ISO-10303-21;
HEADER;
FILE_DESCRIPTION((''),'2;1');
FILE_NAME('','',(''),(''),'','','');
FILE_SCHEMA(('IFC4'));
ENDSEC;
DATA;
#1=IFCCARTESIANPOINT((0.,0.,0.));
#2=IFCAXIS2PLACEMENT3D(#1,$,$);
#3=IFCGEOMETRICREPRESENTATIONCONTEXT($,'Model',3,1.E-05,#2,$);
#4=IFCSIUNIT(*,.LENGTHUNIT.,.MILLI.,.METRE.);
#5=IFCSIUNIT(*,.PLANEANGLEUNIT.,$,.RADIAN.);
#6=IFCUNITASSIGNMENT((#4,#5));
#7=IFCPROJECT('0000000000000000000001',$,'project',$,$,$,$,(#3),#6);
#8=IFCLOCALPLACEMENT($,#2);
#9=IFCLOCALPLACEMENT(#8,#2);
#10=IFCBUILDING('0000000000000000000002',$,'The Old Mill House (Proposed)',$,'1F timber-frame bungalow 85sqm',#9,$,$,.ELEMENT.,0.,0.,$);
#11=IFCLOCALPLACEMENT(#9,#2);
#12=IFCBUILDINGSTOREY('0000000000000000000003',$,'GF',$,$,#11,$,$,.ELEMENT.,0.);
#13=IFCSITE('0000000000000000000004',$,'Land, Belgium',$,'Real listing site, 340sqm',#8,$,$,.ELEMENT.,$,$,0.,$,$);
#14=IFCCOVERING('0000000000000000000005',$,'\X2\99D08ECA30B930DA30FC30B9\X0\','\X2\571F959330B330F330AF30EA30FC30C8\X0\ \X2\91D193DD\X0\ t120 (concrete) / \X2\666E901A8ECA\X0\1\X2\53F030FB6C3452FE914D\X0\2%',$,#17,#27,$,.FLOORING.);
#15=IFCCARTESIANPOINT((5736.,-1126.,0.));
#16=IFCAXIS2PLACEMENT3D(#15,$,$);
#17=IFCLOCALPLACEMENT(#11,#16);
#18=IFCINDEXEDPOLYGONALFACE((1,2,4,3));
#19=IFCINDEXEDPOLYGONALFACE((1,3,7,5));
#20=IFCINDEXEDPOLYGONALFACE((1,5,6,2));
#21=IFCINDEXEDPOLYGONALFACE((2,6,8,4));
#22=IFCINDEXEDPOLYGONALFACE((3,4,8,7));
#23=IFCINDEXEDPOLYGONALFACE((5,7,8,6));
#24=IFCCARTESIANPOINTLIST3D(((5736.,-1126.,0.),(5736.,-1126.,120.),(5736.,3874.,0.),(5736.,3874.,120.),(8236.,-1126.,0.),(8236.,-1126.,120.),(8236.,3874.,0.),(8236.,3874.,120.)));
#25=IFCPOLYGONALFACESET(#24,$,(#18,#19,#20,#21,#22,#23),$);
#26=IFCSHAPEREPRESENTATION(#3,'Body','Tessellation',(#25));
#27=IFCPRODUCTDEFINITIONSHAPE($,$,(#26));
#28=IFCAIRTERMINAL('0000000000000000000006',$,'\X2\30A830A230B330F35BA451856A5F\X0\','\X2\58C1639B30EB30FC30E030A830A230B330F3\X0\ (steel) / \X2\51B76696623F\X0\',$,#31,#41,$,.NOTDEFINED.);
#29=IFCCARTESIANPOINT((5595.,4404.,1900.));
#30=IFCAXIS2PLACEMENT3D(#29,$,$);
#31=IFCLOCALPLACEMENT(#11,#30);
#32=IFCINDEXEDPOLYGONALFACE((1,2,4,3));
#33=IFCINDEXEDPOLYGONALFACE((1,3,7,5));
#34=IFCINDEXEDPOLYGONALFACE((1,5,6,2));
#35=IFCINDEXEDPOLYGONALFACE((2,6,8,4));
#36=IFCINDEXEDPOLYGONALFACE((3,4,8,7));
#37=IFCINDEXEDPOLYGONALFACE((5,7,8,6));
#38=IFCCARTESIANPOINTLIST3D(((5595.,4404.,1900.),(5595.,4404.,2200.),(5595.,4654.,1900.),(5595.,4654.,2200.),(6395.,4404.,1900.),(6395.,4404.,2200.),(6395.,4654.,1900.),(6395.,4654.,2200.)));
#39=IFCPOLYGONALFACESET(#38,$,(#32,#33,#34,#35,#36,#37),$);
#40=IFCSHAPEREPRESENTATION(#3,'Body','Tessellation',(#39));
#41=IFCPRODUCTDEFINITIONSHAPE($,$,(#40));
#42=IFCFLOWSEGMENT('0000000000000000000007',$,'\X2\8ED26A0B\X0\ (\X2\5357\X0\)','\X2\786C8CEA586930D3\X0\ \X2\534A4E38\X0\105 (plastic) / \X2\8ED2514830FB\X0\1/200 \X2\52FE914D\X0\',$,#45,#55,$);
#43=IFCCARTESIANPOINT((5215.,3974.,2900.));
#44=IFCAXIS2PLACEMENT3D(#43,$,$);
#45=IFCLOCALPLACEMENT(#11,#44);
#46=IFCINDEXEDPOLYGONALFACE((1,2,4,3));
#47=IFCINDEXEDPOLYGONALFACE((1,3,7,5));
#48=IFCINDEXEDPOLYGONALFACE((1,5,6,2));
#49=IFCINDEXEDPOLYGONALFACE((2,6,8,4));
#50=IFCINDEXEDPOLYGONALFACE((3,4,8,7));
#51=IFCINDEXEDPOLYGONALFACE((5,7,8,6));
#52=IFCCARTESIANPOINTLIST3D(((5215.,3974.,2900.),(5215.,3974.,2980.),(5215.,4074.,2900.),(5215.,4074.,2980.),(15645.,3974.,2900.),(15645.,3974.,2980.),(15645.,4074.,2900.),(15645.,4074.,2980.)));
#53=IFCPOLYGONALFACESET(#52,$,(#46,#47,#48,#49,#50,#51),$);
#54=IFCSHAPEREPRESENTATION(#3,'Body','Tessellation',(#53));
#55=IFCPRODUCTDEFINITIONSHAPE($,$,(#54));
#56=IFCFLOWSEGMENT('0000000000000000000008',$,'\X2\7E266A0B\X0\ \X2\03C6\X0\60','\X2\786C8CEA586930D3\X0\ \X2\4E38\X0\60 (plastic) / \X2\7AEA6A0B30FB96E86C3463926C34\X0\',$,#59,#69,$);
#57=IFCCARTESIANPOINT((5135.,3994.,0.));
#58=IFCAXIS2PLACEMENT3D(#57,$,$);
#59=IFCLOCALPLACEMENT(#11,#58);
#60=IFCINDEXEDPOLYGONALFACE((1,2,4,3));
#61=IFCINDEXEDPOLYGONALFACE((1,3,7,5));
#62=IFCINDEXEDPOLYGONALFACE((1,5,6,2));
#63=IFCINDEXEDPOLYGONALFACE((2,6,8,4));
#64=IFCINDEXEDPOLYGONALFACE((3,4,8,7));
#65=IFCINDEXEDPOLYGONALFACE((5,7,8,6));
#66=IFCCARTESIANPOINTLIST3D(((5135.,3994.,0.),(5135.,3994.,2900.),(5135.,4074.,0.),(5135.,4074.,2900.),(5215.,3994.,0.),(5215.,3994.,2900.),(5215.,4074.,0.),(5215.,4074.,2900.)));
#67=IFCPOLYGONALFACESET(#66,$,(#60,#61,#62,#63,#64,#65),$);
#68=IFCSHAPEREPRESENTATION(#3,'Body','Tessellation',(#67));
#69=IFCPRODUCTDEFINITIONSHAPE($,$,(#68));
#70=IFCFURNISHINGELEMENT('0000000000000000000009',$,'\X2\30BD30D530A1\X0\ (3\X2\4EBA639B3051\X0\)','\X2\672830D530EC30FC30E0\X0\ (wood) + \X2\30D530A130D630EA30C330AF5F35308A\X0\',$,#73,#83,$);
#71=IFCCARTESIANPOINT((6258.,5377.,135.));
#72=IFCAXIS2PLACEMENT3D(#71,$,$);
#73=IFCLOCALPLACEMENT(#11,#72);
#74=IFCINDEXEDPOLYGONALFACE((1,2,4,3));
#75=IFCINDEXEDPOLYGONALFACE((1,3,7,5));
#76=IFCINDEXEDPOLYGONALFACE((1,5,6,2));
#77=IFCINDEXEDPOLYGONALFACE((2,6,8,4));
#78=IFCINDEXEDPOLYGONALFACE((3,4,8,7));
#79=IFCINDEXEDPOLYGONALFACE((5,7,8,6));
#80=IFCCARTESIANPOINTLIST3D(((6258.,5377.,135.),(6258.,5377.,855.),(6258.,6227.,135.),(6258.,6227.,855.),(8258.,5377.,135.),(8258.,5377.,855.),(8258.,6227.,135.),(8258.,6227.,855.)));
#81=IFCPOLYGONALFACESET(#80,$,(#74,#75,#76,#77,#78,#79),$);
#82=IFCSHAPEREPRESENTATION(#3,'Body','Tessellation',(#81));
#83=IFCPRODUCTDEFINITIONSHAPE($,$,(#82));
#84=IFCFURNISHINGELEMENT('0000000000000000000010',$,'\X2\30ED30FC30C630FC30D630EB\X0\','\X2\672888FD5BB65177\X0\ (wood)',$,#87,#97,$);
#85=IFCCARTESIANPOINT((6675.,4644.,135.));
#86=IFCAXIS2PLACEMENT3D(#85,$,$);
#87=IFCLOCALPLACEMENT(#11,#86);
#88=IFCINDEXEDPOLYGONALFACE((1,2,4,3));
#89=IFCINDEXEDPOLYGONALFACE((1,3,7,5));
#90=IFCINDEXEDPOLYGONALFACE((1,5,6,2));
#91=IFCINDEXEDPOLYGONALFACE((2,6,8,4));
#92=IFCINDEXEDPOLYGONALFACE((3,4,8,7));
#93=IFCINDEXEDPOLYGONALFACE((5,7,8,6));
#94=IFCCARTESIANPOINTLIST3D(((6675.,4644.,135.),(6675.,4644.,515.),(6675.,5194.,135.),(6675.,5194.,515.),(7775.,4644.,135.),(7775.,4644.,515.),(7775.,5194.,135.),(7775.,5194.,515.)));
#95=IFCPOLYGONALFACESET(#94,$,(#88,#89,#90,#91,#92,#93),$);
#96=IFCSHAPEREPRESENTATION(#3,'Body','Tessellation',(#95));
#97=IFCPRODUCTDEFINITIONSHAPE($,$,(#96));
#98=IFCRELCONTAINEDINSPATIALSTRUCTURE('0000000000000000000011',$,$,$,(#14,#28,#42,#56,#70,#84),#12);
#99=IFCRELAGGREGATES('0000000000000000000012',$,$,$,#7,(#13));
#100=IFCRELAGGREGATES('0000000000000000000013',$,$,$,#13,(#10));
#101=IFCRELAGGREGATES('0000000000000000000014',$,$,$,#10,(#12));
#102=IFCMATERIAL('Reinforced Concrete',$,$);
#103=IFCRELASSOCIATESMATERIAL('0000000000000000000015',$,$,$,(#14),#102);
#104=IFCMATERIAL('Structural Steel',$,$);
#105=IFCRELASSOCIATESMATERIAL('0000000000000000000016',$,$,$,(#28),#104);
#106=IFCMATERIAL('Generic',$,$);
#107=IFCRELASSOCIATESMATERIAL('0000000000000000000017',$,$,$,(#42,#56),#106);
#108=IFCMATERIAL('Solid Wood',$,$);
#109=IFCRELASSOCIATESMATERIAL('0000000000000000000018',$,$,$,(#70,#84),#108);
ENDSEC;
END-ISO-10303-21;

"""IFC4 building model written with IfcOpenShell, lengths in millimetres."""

from ifc_helpers import new_model, si_unit, frame, frame_2d, origin, place, context, project, spatial, rectangle, extrude, material, element, save


model = new_model("IFC4")

# Units and contexts
model_context = context("Model", 3, precision=1e-05, world=origin())
ifc_project = project(units=[si_unit("LENGTHUNIT", "METRE", prefix="MILLI"), si_unit("PLANEANGLEUNIT", "RADIAN")], contexts=[model_context])

# Site, building, storey
site_placement = place(None, origin())
site = spatial("IfcSite", under=ifc_project, at=site_placement, Name="Land, Belgium", ObjectType="Real listing site, 340sqm", CompositionType="ELEMENT", RefElevation=0.0)
building_placement = place(site_placement, origin())
building = spatial("IfcBuilding", under=site, at=building_placement, Name="The Old Mill House (Proposed)", ObjectType="1F timber-frame bungalow 85sqm", CompositionType="ELEMENT", ElevationOfRefHeight=0.0, ElevationOfTerrain=0.0)
storey_placement = place(building_placement, origin())
storey = spatial("IfcBuildingStorey", under=building, at=storey_placement, Name="GF", CompositionType="ELEMENT", Elevation=0.0)

# Shared definitions
ifc_material_1 = material(Name="Solid Wood")

# Shared definitions
ifc_material_2 = material(Name="Reinforced Concrete")

# Shared definitions
ifc_material_3 = material(Name="Structural Steel")

# Covering
ifc_material_4 = material(Name="Generic")
covering_1_placement = place(storey_placement, frame((5736.0, -1126.0, 0.0)))
element("IfcCovering", 1, at=covering_1_placement, inside=storey, material=ifc_material_2, Name="駐車スペース", Description="土間コンクリート 金鏝 t120 (concrete) / 普通車1台・水勾配2%", PredefinedType="FLOORING", context=model_context, shape_type="SweptSolid", body=[
    extrude(rectangle(XDim=2500.0, YDim=5000.0, at=frame_2d((1250.0, 2500.0))), frame((5736.0, -1126.0, 0.0)), (0.0, 0.0, 1.0), 120.0),
])

# Air terminal
air_terminal_placement = place(storey_placement, frame((5595.0, 4404.0, 1900.0)))
element("IfcAirTerminal", 2, at=air_terminal_placement, inside=storey, material=ifc_material_3, Name="エアコン室内機", Description="壁掛ルームエアコン (steel) / 冷暖房", PredefinedType="NOTDEFINED", context=model_context, shape_type="SweptSolid", body=[
    extrude(rectangle(XDim=800.0, YDim=250.0, at=frame_2d((400.0, 125.0))), frame((5595.0, 4404.0, 1900.0)), (0.0, 0.0, 1.0), 300.0),
])

# Flow segments
flow_segment_1_placement = place(storey_placement, frame((5215.0, 3974.0, 2900.0)))
element("IfcFlowSegment", 3, at=flow_segment_1_placement, inside=storey, material=ifc_material_4, Name="軒樋 (南)", Description="硬質塩ビ 半丸105 (plastic) / 軒先・1/200 勾配", context=model_context, shape_type="SweptSolid", body=[
    extrude(rectangle(XDim=10430.0, YDim=100.0, at=frame_2d((5215.0, 50.0))), frame((5215.0, 3974.0, 2900.0)), (0.0, 0.0, 1.0), 80.0),
])
flow_segment_2_placement = place(storey_placement, frame((5135.0, 3994.0, 0.0)))
element("IfcFlowSegment", 4, at=flow_segment_2_placement, inside=storey, material=ifc_material_4, Name="縦樋 φ60", Description="硬質塩ビ 丸60 (plastic) / 竪樋・雨水排水", context=model_context, shape_type="SweptSolid", body=[
    extrude(rectangle(XDim=80.0, YDim=80.0, at=frame_2d((40.0, 40.0))), frame((5135.0, 3994.0, 0.0)), (0.0, 0.0, 1.0), 2900.0),
])

# Furnishing elements
furnishing_1_placement = place(storey_placement, frame((6258.0, 5377.0, 135.0)))
element("IfcFurnishingElement", 5, at=furnishing_1_placement, inside=storey, material=ifc_material_1, Name="ソファ (3人掛け)", Description="木フレーム (wood) + ファブリック張り", context=model_context, shape_type="SweptSolid", body=[
    extrude(rectangle(XDim=2000.0, YDim=850.0, at=frame_2d((1000.0, 425.0))), frame((6258.0, 5377.0, 135.0)), (0.0, 0.0, 1.0), 720.0),
])
furnishing_2_placement = place(storey_placement, frame((6675.0, 4644.0, 135.0)))
element("IfcFurnishingElement", 6, at=furnishing_2_placement, inside=storey, material=ifc_material_1, Name="ローテーブル", Description="木製家具 (wood)", context=model_context, shape_type="SweptSolid", body=[
    extrude(rectangle(XDim=1100.0, YDim=550.0, at=frame_2d((550.0, 275.0))), frame((6675.0, 4644.0, 135.0)), (0.0, 0.0, 1.0), 380.0),
])

save(model, "model.ifc")
